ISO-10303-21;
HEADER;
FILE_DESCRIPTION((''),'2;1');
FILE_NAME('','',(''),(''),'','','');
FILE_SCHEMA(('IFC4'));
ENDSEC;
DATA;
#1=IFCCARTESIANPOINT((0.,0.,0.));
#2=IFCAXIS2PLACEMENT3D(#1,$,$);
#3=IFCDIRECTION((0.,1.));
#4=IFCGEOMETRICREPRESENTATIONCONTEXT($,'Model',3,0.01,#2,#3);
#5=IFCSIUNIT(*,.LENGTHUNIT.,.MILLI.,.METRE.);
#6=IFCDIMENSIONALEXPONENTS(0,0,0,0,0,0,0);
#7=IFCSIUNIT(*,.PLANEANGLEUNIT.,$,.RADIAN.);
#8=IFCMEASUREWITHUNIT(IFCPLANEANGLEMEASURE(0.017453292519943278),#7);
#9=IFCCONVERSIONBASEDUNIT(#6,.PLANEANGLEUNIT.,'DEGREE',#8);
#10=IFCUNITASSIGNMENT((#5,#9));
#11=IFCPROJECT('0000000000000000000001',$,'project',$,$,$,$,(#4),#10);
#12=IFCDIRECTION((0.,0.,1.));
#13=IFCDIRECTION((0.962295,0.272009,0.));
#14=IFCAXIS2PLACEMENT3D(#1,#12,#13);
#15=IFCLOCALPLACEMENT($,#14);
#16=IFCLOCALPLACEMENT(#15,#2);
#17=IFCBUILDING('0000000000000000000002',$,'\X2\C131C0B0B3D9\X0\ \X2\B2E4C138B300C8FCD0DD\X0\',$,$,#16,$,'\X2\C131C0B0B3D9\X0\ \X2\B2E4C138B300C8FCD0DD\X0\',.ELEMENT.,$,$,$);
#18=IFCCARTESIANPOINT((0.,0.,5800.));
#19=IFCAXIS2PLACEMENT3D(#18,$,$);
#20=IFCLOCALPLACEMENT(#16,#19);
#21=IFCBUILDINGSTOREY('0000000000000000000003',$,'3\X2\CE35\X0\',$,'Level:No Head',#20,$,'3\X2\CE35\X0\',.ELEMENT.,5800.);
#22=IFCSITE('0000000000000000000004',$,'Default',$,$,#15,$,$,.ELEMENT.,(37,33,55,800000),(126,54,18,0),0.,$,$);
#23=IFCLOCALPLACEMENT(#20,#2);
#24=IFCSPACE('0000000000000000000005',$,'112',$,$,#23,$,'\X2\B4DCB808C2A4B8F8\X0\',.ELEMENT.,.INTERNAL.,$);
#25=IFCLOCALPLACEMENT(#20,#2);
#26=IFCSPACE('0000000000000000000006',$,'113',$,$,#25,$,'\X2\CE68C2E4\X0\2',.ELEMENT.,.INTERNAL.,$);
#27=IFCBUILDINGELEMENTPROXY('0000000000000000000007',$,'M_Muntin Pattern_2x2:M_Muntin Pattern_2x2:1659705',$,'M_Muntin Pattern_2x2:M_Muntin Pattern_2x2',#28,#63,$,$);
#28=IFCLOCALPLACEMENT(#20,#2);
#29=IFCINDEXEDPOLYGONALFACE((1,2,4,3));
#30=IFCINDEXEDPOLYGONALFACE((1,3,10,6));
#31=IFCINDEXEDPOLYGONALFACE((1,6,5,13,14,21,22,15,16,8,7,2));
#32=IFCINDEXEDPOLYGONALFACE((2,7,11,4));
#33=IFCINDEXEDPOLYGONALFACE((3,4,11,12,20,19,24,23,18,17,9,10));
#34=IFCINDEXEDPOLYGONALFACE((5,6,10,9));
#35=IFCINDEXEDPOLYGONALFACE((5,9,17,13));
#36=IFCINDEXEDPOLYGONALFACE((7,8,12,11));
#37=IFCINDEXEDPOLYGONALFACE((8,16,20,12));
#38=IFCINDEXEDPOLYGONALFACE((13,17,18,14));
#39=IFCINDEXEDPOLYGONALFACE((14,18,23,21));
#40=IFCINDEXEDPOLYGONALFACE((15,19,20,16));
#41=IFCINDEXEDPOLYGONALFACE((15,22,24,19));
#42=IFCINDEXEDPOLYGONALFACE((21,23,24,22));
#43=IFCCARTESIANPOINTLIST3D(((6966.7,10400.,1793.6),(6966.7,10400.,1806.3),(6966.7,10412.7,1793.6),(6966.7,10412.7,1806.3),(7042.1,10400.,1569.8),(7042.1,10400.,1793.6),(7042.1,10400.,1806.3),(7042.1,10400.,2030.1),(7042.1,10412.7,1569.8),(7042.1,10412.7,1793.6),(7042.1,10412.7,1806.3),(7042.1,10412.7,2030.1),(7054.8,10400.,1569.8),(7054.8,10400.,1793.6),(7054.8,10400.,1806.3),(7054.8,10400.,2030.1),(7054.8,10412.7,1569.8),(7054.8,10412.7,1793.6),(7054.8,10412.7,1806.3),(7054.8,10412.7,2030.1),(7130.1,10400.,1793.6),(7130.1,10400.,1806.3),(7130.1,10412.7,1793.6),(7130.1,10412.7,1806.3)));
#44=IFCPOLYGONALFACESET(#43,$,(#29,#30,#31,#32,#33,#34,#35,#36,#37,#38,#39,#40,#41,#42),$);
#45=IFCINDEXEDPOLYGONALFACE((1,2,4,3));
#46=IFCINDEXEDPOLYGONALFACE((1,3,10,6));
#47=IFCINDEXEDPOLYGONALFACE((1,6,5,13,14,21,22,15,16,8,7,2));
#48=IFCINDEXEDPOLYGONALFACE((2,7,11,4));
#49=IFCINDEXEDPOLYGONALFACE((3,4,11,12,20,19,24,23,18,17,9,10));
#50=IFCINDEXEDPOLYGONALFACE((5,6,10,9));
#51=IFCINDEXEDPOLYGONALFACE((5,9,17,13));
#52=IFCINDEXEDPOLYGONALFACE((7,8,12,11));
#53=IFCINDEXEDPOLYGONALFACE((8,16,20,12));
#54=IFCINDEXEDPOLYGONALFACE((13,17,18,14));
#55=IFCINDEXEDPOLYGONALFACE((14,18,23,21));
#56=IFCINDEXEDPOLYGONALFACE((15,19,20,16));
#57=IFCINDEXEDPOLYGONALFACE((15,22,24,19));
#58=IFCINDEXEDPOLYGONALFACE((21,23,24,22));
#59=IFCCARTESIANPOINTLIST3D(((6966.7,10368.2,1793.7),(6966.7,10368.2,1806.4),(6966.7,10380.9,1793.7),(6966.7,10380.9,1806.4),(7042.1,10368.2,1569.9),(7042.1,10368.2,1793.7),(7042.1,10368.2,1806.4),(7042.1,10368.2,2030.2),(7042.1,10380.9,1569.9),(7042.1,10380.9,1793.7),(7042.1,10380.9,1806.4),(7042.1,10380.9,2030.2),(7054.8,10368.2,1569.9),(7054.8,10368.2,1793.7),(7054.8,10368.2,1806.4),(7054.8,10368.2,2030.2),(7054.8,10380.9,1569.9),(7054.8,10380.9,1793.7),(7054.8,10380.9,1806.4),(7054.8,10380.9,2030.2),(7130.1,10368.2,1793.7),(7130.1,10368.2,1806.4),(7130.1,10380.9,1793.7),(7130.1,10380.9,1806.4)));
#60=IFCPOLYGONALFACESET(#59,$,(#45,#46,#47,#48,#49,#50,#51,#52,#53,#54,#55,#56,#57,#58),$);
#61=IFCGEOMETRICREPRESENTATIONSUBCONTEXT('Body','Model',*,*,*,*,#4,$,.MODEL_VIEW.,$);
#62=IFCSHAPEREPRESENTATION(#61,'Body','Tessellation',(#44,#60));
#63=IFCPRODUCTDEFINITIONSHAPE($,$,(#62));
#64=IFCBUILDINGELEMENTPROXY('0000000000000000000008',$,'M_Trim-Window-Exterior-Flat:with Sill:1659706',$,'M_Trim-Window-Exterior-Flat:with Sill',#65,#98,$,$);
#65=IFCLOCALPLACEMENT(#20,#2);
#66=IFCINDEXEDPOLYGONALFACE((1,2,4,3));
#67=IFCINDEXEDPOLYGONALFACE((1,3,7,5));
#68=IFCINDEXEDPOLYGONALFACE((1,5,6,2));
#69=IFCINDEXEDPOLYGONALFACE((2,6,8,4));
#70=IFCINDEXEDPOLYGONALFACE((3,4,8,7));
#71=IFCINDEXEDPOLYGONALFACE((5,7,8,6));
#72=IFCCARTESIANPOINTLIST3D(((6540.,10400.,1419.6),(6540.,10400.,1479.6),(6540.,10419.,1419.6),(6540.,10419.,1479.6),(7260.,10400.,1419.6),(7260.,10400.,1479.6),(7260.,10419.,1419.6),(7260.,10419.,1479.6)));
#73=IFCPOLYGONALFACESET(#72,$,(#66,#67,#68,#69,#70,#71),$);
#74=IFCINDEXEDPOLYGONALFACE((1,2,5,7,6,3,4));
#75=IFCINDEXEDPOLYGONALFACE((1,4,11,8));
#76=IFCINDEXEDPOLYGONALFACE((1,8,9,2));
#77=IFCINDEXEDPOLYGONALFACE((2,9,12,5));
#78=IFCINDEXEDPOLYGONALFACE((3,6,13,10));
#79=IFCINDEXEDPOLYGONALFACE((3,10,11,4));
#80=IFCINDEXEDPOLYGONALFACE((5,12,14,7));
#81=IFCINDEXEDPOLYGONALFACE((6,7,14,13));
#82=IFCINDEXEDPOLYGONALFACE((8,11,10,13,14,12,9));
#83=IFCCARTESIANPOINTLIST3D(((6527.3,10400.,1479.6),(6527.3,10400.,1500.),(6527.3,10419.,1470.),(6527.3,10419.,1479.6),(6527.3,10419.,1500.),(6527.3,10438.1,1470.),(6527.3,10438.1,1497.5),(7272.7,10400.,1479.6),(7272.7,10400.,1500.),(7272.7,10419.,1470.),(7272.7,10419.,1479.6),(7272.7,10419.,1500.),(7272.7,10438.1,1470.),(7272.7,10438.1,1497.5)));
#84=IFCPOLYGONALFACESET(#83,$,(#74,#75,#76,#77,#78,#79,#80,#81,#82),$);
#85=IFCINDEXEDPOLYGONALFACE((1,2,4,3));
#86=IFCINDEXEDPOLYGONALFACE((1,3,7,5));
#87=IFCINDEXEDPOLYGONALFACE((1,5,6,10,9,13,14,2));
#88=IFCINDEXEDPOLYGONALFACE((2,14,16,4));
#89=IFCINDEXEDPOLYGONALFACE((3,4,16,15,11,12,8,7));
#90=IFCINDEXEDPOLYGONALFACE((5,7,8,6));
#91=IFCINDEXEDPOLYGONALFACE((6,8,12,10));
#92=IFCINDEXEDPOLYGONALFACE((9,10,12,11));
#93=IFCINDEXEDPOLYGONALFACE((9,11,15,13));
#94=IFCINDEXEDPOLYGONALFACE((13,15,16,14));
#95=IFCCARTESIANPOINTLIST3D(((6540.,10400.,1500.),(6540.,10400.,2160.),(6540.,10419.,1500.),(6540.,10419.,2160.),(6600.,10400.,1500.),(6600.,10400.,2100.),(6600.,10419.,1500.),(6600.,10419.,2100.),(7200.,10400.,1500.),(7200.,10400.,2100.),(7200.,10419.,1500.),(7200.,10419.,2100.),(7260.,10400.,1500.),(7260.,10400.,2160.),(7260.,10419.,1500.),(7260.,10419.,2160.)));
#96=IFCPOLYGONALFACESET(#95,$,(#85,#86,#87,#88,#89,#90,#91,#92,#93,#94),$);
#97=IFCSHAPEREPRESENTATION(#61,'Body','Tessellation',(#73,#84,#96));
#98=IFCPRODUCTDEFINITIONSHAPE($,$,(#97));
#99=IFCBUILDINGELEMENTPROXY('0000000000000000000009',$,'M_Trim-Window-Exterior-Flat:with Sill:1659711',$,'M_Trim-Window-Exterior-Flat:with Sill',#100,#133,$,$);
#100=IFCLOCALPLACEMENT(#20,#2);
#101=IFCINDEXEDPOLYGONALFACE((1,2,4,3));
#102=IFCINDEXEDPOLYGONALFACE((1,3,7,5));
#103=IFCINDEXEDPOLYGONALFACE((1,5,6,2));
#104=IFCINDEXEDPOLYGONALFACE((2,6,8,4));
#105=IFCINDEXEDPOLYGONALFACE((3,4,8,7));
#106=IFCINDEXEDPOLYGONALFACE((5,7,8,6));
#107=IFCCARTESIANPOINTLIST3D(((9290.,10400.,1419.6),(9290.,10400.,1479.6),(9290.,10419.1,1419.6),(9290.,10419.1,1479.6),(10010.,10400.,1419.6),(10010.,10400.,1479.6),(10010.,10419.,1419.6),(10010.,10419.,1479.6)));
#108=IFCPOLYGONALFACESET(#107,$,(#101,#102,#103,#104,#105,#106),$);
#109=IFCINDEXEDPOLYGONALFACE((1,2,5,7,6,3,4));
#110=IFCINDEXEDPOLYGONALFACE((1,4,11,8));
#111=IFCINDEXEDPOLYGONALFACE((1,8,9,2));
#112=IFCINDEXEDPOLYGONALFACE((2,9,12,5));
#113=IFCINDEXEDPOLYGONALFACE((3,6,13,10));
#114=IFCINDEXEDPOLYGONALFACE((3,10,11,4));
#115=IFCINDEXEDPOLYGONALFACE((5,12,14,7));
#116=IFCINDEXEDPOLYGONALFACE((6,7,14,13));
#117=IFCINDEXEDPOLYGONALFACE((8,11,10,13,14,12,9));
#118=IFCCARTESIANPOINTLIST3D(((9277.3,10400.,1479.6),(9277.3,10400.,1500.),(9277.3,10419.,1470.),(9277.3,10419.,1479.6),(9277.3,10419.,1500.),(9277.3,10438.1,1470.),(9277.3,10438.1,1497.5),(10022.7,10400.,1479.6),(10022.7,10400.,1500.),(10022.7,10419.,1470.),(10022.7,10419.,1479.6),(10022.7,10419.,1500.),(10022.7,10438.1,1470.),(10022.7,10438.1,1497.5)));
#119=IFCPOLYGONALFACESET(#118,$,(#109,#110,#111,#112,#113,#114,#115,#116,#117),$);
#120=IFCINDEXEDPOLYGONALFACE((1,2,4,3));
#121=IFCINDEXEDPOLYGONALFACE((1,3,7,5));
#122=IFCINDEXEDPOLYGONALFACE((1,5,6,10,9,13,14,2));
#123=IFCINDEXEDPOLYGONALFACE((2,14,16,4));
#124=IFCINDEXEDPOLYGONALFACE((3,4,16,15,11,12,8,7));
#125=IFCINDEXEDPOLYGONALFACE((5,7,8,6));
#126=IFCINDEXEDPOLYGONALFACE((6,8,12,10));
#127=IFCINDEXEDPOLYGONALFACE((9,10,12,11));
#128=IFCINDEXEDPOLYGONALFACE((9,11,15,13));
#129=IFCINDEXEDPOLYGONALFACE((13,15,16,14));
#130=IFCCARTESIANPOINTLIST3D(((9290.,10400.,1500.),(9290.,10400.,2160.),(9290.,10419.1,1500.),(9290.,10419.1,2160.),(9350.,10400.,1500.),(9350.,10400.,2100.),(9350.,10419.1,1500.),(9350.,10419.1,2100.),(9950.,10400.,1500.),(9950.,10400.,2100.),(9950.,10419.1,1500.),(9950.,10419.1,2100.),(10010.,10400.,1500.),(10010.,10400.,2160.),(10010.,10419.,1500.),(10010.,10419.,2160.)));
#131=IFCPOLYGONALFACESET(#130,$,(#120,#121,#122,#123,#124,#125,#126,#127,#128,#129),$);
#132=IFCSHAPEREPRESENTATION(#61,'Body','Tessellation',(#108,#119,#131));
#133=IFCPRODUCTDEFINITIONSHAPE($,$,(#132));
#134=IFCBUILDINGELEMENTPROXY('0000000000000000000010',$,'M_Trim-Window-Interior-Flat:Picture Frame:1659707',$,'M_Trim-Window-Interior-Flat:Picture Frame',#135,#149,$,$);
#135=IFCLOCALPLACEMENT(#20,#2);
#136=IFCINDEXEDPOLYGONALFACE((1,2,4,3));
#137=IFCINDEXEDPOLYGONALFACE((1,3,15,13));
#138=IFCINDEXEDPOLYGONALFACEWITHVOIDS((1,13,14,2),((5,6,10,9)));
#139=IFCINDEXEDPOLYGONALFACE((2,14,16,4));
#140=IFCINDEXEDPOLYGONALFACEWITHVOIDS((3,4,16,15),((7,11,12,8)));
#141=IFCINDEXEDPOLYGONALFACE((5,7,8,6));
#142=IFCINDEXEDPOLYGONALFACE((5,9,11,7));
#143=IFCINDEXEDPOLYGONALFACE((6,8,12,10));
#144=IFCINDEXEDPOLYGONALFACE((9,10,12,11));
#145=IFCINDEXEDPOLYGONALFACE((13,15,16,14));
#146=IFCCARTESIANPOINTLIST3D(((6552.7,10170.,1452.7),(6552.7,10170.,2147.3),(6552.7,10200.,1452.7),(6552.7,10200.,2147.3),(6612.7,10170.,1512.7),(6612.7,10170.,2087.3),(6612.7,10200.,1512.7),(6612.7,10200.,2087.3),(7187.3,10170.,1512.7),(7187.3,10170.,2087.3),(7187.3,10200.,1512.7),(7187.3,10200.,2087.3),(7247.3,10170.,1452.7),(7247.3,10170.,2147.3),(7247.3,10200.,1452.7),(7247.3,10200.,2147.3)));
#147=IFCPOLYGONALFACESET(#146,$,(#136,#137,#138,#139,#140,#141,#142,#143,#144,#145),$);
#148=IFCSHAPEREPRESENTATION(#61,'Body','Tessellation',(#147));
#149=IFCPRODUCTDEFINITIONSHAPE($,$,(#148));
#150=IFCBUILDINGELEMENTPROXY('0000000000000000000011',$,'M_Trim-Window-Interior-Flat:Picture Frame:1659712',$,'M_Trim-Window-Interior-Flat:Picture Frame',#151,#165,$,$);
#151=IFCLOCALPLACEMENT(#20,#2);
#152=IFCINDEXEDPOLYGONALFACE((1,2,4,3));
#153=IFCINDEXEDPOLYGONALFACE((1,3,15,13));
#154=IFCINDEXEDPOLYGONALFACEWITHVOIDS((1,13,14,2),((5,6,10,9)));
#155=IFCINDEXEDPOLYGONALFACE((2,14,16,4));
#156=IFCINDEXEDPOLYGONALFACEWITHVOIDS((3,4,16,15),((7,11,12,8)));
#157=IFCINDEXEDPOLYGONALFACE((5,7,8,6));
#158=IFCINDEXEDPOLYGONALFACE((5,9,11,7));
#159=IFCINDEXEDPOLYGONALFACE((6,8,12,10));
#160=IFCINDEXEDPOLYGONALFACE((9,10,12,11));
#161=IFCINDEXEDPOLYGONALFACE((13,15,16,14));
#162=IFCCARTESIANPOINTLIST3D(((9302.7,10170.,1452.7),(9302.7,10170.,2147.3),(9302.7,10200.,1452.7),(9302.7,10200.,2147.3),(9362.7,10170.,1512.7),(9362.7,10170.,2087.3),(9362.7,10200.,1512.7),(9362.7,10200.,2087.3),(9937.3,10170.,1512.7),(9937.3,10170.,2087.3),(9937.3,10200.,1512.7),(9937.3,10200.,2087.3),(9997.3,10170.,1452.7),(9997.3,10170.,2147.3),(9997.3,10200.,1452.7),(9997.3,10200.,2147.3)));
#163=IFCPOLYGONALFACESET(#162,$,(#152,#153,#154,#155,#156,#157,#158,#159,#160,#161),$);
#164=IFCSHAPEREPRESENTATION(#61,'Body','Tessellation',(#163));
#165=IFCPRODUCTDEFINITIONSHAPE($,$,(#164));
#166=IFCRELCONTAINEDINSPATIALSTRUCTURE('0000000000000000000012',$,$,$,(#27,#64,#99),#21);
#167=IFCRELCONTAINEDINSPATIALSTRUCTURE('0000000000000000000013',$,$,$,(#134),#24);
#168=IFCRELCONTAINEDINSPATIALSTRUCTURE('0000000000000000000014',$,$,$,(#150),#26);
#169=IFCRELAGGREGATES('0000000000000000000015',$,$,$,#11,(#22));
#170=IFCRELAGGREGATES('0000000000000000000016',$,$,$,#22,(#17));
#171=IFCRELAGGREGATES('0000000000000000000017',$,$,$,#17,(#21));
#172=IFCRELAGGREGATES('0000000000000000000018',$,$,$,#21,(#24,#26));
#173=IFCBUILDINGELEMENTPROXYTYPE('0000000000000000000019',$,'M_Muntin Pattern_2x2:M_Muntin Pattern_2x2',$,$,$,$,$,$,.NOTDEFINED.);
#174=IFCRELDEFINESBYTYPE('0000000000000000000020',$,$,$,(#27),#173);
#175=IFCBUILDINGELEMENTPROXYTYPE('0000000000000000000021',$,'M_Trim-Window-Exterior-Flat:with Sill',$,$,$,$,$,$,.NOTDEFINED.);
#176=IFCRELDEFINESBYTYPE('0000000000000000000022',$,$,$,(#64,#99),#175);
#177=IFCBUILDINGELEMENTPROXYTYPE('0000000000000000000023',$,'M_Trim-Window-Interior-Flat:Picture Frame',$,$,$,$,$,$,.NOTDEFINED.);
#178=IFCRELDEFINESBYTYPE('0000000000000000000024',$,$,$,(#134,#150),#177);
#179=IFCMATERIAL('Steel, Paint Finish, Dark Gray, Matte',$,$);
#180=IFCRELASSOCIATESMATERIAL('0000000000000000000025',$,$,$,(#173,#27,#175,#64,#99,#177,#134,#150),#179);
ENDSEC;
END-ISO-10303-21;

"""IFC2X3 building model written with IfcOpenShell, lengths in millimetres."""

from ifc_helpers import new_model, entity, si_unit, converted_unit, direction, frame, frame_2d, origin, place, context, subcontext, project, spatial, polyline, rectangle, outline, extrude, source, transform, mapped, material, type_object, type_shapes, element, save


model = new_model("IFC2X3")

# Units and contexts
model_context = context("Model", 3, precision=0.01, world=origin(), true_north=direction((0.0, 1.0)))
body_context = subcontext(model_context, "Body", "Model", "MODEL_VIEW")
ifc_project = project(units=[si_unit("LENGTHUNIT", "METRE", prefix="MILLI"), converted_unit("PLANEANGLEUNIT", "DEGREE", entity("IfcPlaneAngleMeasure", 0.017453292519943278), si_unit("PLANEANGLEUNIT", "RADIAN"), dimensions=[0, 0, 0, 0, 0, 0, 0])], contexts=[model_context])

# Site, building, storey
site_placement = place(None, frame((0.0, 0.0, 0.0), z_axis=(0.0, 0.0, 1.0), x_axis=(0.962295, 0.272009, 0.0)))
site = spatial("IfcSite", under=ifc_project, at=site_placement, Name="Default", CompositionType="ELEMENT", RefLatitude=(37, 33, 55, 800000), RefLongitude=(126, 54, 18, 0), RefElevation=0.0)
building_placement = place(site_placement, origin())
building = spatial("IfcBuilding", under=site, at=building_placement, Name="성산동 다세대주택", LongName="성산동 다세대주택", CompositionType="ELEMENT")
storey_placement = place(building_placement, frame((0.0, 0.0, 5800.0)))
storey = spatial("IfcBuildingStorey", under=building, at=storey_placement, Name="3층", ObjectType="Level:No Head", LongName="3층", CompositionType="ELEMENT", Elevation=5800.0)

# Shared definitions
space_1_placement = place(storey_placement, origin())
space_1 = spatial("IfcSpace", under=storey, at=space_1_placement, Name="112", LongName="드레스룸", CompositionType="ELEMENT", InteriorOrExteriorSpace="INTERNAL")

# Building element proxies
ifc_material_1 = material(Name="Steel, Paint Finish, Dark Gray, Matte")
building_element_proxy_type_1 = type_object("IfcBuildingElementProxyType", Name="M_Muntin Pattern_2x2:M_Muntin Pattern_2x2", PredefinedType="NOTDEFINED", material=ifc_material_1)
shared_shape_1 = source(origin(), body_context, "Body", "SweptSolid", [
    extrude(outline(polyline([(6.4, -6.4), (230.1, -6.4), (230.1, 6.3), (6.4, 6.3), (6.4, 81.7), (-6.3, 81.7), (-6.3, 6.3), (-230.2, 6.3), (-230.2, -6.4), (-6.3, -6.4), (-6.3, -81.7), (6.4, -81.7), (6.4, -6.4)])), frame((0.0, -22.2, 230.1), z_axis=(0.0, 1.0, 0.0), x_axis=(0.0, 0.0, 1.0)), (0.0, 0.0, 1.0), 12.7),
    extrude(outline(polyline([(6.4, -6.4), (230.2, -6.4), (230.2, 6.3), (6.4, 6.3), (6.4, 81.7), (-6.3, 81.7), (-6.3, 6.3), (-230.2, 6.3), (-230.2, -6.4), (-6.3, -6.4), (-6.3, -81.7), (6.4, -81.7), (6.4, -6.4)])), frame((0.0, 9.5, 230.2), z_axis=(0.0, 1.0, 0.0), x_axis=(0.0, 0.0, 1.0)), (0.0, 0.0, 1.0), 12.7),
])
type_shapes(building_element_proxy_type_1, [shared_shape_1])
proxy_1_placement = place(storey_placement, frame((7048.4, 10390.5, 1569.9), z_axis=(0.0, 0.0, 1.0), x_axis=(-1.0, 0.0, 0.0)))
element("IfcBuildingElementProxy", 1, at=proxy_1_placement, inside=storey, type_object=building_element_proxy_type_1, material=ifc_material_1, Name="M_Muntin Pattern_2x2:M_Muntin Pattern_2x2:1659705", ObjectType="M_Muntin Pattern_2x2:M_Muntin Pattern_2x2", context=body_context, shape_type="MappedRepresentation", body=[
    mapped(shared_shape_1, transform((0.0, 0.0, 0.0), scale=1.0)),
])
building_element_proxy_type_2 = type_object("IfcBuildingElementProxyType", Name="M_Trim-Window-Exterior-Flat:with Sill", PredefinedType="NOTDEFINED", material=ifc_material_1)
shared_shape_2 = source(origin(), body_context, "Body", "SweptSolid", [
    extrude(rectangle(XDim=720.0, YDim=60.0, at=frame_2d((0.0, 0.0), x_axis=(1.0, 0.0))), frame((0.0, -650.4, 0.0), z_axis=(0.0, 0.0, 1.0), x_axis=(-1.0, 0.0, 0.0)), (0.0, 0.0, 1.0), 19.0),
    extrude(outline(polyline([(-19.0, -15.2), (0.0, -15.2), (0.0, -5.7), (19.0, -5.7), (19.0, 14.8), (0.0, 14.8), (-19.0, 12.3), (-19.0, -15.2)])), frame((-372.7, -614.8, 19.0), z_axis=(1.0, 0.0, 0.0), x_axis=(0.0, 0.0, -1.0)), (0.0, 0.0, 1.0), 745.4),
    extrude(outline(polyline([(-345.0, -360.0), (315.0, -360.0), (315.0, -300.0), (-285.0, -300.0), (-285.0, 300.0), (315.0, 300.0), (315.0, 360.0), (-345.0, 360.0), (-345.0, -360.0)])), frame((0.0, -285.0, 0.0), z_axis=(0.0, 0.0, 1.0), x_axis=(0.0, -1.0, 0.0)), (0.0, 0.0, 1.0), 19.0),
])
type_shapes(building_element_proxy_type_2, [shared_shape_2])
for number, where, z_axis, x_axis, name in (
    (2, (6900.0, 10400.0, 2100.0), (0.0, 1.0, 0.0), (-1.0, 0.0, 0.0), "M_Trim-Window-Exterior-Flat:with Sill:1659706"),
    (3, (9650.0, 10400.0, 2100.0), (0.0, 1.0, 0.0), (-1.0, 0.0, 0.0), "M_Trim-Window-Exterior-Flat:with Sill:1659711"),
):
    element("IfcBuildingElementProxy", number, at=place(storey_placement, frame(where, z_axis=z_axis, x_axis=x_axis)), inside=storey, type_object=building_element_proxy_type_2, material=ifc_material_1, Name=name, ObjectType="M_Trim-Window-Exterior-Flat:with Sill", context=body_context, shape_type="MappedRepresentation", body=[
        mapped(shared_shape_2, transform((0.0, 0.0, 0.0), scale=1.0)),
    ])
building_element_proxy_type_3 = type_object("IfcBuildingElementProxyType", Name="M_Trim-Window-Interior-Flat:Picture Frame", PredefinedType="NOTDEFINED", material=ifc_material_1)
shared_shape_3 = source(origin(), body_context, "Body", "SweptSolid", [
    extrude(outline(polyline([(-347.3, -347.3), (347.3, -347.3), (347.3, 347.3), (-347.3, 347.3), (-347.3, -347.3)]), holes=[polyline([(-287.3, -287.3), (-287.3, 287.3), (287.3, 287.3), (287.3, -287.3), (-287.3, -287.3)])]), frame((0.0, -300.0, 0.0), z_axis=(0.0, 0.0, 1.0), x_axis=(-1.0, 0.0, 0.0)), (0.0, 0.0, 1.0), 30.0),
])
type_shapes(building_element_proxy_type_3, [shared_shape_3])
proxy_2_placement = place(space_1_placement, frame((6900.0, 10200.0, 2100.0), z_axis=(0.0, -1.0, 0.0), x_axis=(1.0, 0.0, 0.0)))
element("IfcBuildingElementProxy", 4, at=proxy_2_placement, inside=space_1, type_object=building_element_proxy_type_3, material=ifc_material_1, Name="M_Trim-Window-Interior-Flat:Picture Frame:1659707", ObjectType="M_Trim-Window-Interior-Flat:Picture Frame", context=body_context, shape_type="MappedRepresentation", body=[
    mapped(shared_shape_3, transform((0.0, 0.0, 0.0), scale=1.0)),
])

# Shared definitions
space_2_placement = place(storey_placement, origin())
space_2 = spatial("IfcSpace", under=storey, at=space_2_placement, Name="113", LongName="침실2", CompositionType="ELEMENT", InteriorOrExteriorSpace="INTERNAL")

# Building element proxy
proxy_3_placement = place(space_2_placement, frame((9650.0, 10200.0, 2100.0), z_axis=(0.0, -1.0, 0.0), x_axis=(1.0, 0.0, 0.0)))
element("IfcBuildingElementProxy", 5, at=proxy_3_placement, inside=space_2, type_object=building_element_proxy_type_3, material=ifc_material_1, Name="M_Trim-Window-Interior-Flat:Picture Frame:1659712", ObjectType="M_Trim-Window-Interior-Flat:Picture Frame", context=body_context, shape_type="MappedRepresentation", body=[
    mapped(shared_shape_3, transform((0.0, 0.0, 0.0), scale=1.0)),
])

save(model, "model.ifc")
